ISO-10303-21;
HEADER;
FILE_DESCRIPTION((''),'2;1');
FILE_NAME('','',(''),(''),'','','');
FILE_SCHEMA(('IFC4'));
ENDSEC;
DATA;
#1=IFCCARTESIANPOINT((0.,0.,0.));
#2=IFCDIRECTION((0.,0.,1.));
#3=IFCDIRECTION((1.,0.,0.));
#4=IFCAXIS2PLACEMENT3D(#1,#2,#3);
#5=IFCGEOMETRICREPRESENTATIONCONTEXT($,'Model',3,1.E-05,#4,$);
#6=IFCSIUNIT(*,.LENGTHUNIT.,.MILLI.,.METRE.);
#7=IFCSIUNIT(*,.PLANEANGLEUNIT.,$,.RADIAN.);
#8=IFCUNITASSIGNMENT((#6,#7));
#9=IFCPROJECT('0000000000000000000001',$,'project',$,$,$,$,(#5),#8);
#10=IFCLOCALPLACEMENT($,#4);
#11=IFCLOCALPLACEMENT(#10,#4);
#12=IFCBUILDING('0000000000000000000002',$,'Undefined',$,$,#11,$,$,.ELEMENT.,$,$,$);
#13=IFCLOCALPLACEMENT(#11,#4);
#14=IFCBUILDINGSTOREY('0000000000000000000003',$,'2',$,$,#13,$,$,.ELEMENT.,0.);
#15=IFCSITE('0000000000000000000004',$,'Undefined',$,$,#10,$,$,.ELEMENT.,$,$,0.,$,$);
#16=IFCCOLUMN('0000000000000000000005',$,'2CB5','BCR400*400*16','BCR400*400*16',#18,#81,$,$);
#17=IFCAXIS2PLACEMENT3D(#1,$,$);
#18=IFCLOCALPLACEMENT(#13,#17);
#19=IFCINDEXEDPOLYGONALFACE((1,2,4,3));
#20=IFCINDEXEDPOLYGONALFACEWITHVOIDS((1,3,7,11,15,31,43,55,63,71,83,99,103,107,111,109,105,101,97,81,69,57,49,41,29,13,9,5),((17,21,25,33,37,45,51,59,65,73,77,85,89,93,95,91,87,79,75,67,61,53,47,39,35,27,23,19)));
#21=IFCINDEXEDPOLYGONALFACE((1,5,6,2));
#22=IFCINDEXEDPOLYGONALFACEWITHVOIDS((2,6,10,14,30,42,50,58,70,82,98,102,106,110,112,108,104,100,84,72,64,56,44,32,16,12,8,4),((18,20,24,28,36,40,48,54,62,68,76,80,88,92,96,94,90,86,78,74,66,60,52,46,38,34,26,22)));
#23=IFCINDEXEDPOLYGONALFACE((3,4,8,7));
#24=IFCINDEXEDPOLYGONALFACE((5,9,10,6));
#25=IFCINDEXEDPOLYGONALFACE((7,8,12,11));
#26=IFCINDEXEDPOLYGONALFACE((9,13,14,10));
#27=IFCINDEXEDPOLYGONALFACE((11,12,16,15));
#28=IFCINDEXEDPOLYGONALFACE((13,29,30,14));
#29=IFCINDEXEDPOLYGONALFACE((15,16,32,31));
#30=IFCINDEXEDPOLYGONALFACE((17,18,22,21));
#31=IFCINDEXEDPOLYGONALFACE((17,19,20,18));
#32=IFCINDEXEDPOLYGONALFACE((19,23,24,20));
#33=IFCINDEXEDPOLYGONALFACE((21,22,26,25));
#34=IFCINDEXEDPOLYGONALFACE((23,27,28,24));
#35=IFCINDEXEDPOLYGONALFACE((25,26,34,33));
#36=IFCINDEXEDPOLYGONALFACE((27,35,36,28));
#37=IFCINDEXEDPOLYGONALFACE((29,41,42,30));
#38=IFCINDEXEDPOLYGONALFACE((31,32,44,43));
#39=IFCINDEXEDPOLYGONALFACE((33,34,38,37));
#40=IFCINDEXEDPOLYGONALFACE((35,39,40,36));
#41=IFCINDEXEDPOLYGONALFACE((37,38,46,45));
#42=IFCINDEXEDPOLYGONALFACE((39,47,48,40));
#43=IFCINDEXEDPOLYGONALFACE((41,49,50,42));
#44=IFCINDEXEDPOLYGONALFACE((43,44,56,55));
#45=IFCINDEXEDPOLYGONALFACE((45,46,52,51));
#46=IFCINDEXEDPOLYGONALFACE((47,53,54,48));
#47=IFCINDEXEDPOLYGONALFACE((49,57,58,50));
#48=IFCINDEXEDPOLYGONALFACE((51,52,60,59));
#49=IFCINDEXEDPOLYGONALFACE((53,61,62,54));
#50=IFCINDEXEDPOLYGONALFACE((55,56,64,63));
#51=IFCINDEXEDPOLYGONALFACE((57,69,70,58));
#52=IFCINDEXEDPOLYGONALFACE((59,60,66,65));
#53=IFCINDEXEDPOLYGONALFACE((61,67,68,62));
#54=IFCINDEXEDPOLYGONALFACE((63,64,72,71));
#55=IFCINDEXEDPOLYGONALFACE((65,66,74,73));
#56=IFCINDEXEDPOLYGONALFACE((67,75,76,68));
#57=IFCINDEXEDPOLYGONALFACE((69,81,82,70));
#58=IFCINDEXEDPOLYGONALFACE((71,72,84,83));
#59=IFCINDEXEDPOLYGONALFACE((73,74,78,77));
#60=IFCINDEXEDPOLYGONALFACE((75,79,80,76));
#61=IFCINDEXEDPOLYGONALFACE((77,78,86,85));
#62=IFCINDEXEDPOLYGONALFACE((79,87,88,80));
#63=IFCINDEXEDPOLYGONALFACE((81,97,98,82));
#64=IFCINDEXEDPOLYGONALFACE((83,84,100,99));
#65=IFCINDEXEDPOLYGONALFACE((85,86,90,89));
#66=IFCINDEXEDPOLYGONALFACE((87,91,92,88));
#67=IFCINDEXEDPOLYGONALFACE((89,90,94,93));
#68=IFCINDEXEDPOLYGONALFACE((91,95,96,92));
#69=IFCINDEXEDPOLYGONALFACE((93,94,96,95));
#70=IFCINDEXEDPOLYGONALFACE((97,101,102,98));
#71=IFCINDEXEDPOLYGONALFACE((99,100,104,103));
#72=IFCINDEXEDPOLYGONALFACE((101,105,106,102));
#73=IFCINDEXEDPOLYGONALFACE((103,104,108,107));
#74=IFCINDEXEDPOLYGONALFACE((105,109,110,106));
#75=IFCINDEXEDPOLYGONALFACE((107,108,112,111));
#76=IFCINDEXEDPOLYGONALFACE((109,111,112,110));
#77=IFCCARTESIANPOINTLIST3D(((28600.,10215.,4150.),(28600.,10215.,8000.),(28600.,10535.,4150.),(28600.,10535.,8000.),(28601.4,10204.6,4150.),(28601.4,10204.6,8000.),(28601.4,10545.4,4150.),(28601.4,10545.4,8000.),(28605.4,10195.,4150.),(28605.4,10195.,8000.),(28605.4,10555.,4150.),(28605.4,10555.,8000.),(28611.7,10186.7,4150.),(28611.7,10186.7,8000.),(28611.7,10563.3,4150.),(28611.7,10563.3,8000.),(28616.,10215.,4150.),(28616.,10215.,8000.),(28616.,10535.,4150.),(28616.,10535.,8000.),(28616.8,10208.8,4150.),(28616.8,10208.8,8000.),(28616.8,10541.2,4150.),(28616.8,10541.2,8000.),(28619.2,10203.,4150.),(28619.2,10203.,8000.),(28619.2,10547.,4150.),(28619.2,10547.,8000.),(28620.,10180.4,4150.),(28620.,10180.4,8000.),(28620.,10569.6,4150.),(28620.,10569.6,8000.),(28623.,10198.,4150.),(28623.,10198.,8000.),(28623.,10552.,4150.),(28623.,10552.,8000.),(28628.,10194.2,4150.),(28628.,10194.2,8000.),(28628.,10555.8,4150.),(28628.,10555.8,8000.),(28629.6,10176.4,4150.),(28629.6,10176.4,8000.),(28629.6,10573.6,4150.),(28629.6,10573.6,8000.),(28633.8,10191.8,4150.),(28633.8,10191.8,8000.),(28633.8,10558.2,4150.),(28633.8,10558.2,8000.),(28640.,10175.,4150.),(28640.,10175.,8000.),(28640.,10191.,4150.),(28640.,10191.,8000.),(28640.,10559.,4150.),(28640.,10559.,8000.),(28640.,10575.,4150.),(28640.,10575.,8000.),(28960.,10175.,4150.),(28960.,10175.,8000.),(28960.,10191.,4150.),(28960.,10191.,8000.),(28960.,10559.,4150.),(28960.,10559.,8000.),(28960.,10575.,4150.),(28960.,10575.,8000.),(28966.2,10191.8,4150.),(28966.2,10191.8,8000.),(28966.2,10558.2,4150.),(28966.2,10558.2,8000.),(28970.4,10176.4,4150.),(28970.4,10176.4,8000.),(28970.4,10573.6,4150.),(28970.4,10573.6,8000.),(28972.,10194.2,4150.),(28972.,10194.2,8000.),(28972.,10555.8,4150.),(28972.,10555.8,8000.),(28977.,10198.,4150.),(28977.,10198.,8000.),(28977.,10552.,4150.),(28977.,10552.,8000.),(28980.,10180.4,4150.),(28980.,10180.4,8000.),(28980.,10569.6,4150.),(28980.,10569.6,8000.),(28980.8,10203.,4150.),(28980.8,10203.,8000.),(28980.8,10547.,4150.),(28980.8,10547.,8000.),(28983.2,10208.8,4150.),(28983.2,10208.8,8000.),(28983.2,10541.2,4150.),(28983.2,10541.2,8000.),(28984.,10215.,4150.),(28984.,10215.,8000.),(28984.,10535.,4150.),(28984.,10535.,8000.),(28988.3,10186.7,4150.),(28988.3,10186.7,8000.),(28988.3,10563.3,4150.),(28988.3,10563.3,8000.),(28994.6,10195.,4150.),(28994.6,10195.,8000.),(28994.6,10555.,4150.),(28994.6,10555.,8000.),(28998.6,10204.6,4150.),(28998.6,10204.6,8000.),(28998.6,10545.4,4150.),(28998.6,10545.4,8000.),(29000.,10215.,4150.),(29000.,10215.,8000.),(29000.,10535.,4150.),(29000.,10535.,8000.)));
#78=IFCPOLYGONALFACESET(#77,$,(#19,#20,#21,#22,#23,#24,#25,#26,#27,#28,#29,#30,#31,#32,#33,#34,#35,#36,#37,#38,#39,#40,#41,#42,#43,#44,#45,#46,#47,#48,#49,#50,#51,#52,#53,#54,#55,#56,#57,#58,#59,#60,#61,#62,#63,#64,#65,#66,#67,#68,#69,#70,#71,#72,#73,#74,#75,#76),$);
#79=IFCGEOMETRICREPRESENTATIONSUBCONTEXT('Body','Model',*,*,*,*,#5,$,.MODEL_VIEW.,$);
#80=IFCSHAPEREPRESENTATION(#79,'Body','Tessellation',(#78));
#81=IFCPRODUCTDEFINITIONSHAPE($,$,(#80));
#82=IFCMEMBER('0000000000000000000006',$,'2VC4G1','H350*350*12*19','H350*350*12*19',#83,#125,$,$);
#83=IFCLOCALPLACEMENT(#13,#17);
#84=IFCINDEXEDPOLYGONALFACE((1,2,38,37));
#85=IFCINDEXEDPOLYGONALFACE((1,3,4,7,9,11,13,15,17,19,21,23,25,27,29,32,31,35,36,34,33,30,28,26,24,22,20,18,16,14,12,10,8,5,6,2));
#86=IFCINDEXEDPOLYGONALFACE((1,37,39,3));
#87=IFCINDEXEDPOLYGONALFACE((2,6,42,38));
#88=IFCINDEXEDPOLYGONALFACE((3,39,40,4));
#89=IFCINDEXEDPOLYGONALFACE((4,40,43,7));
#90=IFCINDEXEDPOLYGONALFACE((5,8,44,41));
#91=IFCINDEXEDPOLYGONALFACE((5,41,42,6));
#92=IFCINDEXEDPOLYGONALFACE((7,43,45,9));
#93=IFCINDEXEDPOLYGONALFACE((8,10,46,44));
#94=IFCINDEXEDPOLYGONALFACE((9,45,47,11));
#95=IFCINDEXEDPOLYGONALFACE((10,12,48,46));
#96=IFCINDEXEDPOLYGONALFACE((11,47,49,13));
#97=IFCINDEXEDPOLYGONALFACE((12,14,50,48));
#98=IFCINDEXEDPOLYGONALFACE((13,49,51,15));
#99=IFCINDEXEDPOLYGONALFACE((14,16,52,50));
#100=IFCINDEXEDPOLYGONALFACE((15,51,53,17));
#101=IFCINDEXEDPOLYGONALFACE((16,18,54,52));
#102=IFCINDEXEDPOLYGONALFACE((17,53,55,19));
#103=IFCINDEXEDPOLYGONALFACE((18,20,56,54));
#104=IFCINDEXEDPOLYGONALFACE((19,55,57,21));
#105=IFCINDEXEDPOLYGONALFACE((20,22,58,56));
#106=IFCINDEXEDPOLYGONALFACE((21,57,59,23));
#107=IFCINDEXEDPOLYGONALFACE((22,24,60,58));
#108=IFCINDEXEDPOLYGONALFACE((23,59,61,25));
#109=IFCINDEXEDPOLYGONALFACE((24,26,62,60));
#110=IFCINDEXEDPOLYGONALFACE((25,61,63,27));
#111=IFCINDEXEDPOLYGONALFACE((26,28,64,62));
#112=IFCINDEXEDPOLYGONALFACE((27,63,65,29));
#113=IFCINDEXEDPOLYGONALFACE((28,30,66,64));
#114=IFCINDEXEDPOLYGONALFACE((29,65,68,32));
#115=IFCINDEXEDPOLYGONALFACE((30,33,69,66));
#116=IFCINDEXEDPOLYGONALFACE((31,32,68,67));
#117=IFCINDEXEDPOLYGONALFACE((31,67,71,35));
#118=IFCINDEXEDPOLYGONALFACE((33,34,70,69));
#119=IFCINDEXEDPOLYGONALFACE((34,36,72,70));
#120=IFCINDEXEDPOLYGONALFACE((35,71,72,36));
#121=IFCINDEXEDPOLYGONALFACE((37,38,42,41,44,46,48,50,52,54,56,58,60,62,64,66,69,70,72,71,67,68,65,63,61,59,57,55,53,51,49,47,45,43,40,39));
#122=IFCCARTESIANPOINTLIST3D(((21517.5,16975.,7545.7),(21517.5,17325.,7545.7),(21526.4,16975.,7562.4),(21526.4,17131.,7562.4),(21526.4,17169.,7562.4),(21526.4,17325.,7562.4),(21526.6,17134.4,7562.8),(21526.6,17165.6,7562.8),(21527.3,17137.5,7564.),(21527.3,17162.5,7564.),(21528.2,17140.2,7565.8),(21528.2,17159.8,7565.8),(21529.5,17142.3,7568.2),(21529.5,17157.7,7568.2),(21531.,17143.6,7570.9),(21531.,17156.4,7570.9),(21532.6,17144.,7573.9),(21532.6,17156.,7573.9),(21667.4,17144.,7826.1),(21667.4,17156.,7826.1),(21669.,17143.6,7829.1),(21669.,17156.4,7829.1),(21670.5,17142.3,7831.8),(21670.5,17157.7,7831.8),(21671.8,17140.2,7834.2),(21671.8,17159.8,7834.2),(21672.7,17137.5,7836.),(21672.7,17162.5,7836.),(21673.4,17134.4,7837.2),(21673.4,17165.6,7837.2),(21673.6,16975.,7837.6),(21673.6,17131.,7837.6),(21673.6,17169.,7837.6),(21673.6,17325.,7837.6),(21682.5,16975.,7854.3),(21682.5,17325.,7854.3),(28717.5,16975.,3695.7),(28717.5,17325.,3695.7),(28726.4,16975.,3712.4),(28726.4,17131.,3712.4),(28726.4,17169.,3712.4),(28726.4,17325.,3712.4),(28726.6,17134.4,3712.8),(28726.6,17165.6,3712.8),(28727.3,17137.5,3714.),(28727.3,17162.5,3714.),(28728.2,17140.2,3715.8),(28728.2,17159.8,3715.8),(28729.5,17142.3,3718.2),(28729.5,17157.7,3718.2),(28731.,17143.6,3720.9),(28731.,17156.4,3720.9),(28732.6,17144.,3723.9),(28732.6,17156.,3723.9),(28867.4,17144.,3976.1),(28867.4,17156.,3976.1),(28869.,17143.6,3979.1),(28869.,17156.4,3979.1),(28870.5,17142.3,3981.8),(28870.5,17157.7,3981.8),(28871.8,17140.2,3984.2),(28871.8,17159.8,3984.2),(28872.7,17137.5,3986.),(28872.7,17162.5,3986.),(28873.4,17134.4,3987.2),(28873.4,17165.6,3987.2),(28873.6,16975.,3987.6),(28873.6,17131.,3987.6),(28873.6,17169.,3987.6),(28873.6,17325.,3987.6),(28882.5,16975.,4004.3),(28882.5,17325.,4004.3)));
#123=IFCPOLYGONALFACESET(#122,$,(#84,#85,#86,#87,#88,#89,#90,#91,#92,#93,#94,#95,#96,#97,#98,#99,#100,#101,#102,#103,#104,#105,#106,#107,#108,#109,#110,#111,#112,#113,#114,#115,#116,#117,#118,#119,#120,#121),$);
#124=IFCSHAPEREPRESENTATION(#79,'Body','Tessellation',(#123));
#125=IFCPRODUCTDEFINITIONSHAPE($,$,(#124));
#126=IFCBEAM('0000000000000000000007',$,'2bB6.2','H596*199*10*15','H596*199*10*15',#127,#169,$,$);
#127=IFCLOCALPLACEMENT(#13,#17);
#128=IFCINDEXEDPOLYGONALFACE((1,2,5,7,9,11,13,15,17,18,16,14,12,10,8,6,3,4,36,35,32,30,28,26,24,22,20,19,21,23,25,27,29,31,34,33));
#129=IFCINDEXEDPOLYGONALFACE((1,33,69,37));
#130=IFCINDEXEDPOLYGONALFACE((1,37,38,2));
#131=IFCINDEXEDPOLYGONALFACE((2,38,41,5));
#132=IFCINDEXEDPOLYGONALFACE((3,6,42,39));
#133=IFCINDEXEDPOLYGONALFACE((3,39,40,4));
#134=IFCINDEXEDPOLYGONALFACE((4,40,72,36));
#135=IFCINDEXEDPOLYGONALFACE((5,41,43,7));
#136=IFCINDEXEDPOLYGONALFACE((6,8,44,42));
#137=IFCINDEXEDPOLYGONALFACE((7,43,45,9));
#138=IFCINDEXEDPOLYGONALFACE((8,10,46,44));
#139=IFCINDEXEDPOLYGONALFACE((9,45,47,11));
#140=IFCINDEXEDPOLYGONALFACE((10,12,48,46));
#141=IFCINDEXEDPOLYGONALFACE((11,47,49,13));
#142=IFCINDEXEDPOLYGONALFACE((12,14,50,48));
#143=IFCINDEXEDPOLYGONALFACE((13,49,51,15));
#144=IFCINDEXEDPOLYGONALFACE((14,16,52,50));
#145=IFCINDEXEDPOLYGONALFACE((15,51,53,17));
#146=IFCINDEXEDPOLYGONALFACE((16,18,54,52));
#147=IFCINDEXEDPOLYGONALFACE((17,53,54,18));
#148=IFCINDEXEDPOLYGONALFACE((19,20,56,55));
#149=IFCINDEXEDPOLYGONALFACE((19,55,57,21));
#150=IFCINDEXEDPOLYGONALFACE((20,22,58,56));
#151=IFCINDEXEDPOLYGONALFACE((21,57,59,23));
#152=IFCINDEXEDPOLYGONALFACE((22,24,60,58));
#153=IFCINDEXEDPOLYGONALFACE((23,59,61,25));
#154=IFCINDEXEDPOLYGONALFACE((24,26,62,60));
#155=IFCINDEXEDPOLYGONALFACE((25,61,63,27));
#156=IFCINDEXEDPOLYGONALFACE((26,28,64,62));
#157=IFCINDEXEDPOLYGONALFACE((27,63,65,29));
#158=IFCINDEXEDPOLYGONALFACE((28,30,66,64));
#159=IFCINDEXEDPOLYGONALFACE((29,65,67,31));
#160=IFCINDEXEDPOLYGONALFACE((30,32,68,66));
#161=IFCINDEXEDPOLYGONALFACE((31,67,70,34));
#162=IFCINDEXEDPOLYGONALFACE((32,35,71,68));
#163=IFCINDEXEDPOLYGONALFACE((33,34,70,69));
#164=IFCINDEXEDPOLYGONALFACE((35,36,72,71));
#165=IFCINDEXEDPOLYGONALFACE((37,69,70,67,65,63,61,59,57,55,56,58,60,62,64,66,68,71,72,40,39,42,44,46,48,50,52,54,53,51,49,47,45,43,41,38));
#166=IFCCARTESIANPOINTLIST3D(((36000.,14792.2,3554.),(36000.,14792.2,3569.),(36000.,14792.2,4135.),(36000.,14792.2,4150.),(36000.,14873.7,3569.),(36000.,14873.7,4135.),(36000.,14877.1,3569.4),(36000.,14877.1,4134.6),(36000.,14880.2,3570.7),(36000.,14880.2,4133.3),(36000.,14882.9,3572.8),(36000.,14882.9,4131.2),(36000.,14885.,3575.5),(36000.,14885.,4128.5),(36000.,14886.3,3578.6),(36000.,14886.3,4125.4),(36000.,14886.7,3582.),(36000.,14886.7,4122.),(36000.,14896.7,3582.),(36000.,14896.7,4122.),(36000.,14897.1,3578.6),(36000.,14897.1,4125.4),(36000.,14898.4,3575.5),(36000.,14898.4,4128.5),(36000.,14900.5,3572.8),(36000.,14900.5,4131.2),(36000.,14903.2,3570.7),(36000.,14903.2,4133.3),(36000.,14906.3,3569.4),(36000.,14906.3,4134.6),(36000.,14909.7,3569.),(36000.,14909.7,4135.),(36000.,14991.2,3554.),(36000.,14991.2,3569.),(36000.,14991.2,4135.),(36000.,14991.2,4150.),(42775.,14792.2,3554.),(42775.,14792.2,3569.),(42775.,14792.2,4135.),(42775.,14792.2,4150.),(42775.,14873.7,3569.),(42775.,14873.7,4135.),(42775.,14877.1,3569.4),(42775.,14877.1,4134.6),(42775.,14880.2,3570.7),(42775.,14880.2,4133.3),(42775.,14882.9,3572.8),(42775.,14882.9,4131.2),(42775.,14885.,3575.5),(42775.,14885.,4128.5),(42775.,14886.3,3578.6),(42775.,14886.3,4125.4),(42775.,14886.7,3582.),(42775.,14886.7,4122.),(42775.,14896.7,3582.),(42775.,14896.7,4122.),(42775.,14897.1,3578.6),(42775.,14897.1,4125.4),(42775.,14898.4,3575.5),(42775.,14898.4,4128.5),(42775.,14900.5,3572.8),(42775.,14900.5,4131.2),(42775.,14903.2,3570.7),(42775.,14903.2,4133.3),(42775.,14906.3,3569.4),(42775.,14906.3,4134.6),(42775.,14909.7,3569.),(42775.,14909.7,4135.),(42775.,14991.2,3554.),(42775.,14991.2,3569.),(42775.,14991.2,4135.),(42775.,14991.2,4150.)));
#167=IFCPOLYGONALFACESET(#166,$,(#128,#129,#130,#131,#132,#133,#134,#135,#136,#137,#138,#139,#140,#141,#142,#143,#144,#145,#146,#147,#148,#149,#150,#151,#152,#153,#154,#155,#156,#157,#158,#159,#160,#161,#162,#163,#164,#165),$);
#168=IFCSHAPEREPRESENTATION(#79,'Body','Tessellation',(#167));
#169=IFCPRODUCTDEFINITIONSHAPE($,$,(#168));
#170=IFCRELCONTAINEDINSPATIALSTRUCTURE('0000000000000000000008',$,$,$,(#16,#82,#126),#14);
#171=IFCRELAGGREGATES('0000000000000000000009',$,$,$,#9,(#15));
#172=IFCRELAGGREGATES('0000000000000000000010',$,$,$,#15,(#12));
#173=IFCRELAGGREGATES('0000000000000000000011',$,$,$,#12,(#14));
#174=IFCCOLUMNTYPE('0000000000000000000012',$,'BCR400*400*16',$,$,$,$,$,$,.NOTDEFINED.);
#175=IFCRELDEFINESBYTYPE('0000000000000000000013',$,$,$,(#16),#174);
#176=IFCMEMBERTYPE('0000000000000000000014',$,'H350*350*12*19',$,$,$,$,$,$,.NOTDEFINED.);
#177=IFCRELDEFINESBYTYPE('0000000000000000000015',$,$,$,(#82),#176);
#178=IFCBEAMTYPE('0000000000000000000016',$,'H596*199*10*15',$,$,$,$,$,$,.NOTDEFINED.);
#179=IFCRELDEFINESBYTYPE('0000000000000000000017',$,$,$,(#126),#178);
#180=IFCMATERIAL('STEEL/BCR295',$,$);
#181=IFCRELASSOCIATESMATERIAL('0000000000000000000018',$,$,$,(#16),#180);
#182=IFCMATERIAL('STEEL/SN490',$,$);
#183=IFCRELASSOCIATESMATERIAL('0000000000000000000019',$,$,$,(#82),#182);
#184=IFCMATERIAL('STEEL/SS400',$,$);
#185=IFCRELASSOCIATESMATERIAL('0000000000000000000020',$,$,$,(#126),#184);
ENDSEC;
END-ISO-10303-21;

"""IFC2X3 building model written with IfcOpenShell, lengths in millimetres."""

from ifc_helpers import new_model, si_unit, frame, origin_with_axes, origin_2d_with_axis, place, context, subcontext, project, spatial, hollow_rectangle, i_section, extrude, material, type_object, element, save


model = new_model("IFC2X3")

# Units and contexts
model_context = context("Model", 3, precision=1e-05, world=origin_with_axes())
body_context = subcontext(model_context, "Body", "Model", "MODEL_VIEW")
ifc_project = project(units=[si_unit("LENGTHUNIT", "METRE", prefix="MILLI"), si_unit("PLANEANGLEUNIT", "RADIAN")], contexts=[model_context])

# Site, building, storey
site_placement = place(None, origin_with_axes())
site = spatial("IfcSite", under=ifc_project, at=site_placement, Name="Undefined", CompositionType="ELEMENT", RefElevation=0.0)
building_placement = place(site_placement, origin_with_axes())
building = spatial("IfcBuilding", under=site, at=building_placement, Name="Undefined", CompositionType="ELEMENT")
storey_placement = place(building_placement, origin_with_axes())
storey = spatial("IfcBuildingStorey", under=building, at=storey_placement, Name="2", CompositionType="ELEMENT", Elevation=0.0)

# Column
ifc_material_1 = material(Name="STEEL/SN490")
ifc_material_2 = material(Name="STEEL/BCR295")
column_type_1 = type_object("IfcColumnType", Name="BCR400*400*16", PredefinedType="NOTDEFINED")
for number, where, z_axis, x_axis, name in (
    (1, (28800.0, 10375.0, 4150.0), (0.0, 0.0, 1.0), (0.0, 1.0, 0.0), "2CB5"),
):
    element("IfcColumn", number, at=place(storey_placement, frame(where, z_axis=z_axis, x_axis=x_axis)), inside=storey, type_object=column_type_1, material=ifc_material_2, Name=name, Description="BCR400*400*16", ObjectType="BCR400*400*16", context=body_context, shape_type="SweptSolid", body=[
        extrude(hollow_rectangle(XDim=400.0, YDim=400.0, WallThickness=16.0, InnerFilletRadius=24.0, OuterFilletRadius=40.0, at=origin_2d_with_axis()), frame((0.0, 0.0, 3850.0), z_axis=(0.0, 0.0, -1.0), x_axis=(0.0, 1.0, 0.0)), (0.0, 0.0, 1.0), 3850.0),
    ])

# Member
member_type = type_object("IfcMemberType", Name="H350*350*12*19", PredefinedType="NOTDEFINED")
member_placement = place(storey_placement, frame((28800.0, 17150.0, 3850.0), z_axis=(0.471542, 0.0, 0.881844), x_axis=(-0.881844, 0.0, 0.471542)))
element("IfcMember", 2, at=member_placement, inside=storey, type_object=member_type, material=ifc_material_1, Name="2VC4G1", Description="H350*350*12*19", ObjectType="H350*350*12*19", context=body_context, shape_type="SweptSolid", body=[
    extrude(i_section(OverallWidth=350.0, OverallDepth=350.0, WebThickness=12.0, FlangeThickness=19.0, FilletRadius=13.0, at=origin_2d_with_axis()), frame((8164.7, 0.0, 0.0), z_axis=(-1.0, 0.0, 0.0), x_axis=(0.0, -1.0, 0.0)), (0.0, 0.0, 1.0), 8164.7),
])

# Beam
ifc_material_3 = material(Name="STEEL/SS400")
beam_type_1 = type_object("IfcBeamType", Name="H596*199*10*15", PredefinedType="NOTDEFINED")
for number, where, z_axis, x_axis, name in (
    (3, (36000.0, 14891.7, 3852.0), (0.0, 0.0, 1.0), (1.0, 0.0, 0.0), "2bB6.2"),
):
    element("IfcBeam", number, at=place(storey_placement, frame(where, z_axis=z_axis, x_axis=x_axis)), inside=storey, type_object=beam_type_1, material=ifc_material_3, Name=name, Description="H596*199*10*15", ObjectType="H596*199*10*15", context=body_context, shape_type="SweptSolid", body=[
        extrude(i_section(OverallWidth=199.0, OverallDepth=596.0, WebThickness=10.0, FlangeThickness=15.0, FilletRadius=13.0, at=origin_2d_with_axis()), frame((6775.0, 0.0, 0.0), z_axis=(-1.0, 0.0, 0.0), x_axis=(0.0, -1.0, 0.0)), (0.0, 0.0, 1.0), 6775.0),
    ])

save(model, "model.ifc")
